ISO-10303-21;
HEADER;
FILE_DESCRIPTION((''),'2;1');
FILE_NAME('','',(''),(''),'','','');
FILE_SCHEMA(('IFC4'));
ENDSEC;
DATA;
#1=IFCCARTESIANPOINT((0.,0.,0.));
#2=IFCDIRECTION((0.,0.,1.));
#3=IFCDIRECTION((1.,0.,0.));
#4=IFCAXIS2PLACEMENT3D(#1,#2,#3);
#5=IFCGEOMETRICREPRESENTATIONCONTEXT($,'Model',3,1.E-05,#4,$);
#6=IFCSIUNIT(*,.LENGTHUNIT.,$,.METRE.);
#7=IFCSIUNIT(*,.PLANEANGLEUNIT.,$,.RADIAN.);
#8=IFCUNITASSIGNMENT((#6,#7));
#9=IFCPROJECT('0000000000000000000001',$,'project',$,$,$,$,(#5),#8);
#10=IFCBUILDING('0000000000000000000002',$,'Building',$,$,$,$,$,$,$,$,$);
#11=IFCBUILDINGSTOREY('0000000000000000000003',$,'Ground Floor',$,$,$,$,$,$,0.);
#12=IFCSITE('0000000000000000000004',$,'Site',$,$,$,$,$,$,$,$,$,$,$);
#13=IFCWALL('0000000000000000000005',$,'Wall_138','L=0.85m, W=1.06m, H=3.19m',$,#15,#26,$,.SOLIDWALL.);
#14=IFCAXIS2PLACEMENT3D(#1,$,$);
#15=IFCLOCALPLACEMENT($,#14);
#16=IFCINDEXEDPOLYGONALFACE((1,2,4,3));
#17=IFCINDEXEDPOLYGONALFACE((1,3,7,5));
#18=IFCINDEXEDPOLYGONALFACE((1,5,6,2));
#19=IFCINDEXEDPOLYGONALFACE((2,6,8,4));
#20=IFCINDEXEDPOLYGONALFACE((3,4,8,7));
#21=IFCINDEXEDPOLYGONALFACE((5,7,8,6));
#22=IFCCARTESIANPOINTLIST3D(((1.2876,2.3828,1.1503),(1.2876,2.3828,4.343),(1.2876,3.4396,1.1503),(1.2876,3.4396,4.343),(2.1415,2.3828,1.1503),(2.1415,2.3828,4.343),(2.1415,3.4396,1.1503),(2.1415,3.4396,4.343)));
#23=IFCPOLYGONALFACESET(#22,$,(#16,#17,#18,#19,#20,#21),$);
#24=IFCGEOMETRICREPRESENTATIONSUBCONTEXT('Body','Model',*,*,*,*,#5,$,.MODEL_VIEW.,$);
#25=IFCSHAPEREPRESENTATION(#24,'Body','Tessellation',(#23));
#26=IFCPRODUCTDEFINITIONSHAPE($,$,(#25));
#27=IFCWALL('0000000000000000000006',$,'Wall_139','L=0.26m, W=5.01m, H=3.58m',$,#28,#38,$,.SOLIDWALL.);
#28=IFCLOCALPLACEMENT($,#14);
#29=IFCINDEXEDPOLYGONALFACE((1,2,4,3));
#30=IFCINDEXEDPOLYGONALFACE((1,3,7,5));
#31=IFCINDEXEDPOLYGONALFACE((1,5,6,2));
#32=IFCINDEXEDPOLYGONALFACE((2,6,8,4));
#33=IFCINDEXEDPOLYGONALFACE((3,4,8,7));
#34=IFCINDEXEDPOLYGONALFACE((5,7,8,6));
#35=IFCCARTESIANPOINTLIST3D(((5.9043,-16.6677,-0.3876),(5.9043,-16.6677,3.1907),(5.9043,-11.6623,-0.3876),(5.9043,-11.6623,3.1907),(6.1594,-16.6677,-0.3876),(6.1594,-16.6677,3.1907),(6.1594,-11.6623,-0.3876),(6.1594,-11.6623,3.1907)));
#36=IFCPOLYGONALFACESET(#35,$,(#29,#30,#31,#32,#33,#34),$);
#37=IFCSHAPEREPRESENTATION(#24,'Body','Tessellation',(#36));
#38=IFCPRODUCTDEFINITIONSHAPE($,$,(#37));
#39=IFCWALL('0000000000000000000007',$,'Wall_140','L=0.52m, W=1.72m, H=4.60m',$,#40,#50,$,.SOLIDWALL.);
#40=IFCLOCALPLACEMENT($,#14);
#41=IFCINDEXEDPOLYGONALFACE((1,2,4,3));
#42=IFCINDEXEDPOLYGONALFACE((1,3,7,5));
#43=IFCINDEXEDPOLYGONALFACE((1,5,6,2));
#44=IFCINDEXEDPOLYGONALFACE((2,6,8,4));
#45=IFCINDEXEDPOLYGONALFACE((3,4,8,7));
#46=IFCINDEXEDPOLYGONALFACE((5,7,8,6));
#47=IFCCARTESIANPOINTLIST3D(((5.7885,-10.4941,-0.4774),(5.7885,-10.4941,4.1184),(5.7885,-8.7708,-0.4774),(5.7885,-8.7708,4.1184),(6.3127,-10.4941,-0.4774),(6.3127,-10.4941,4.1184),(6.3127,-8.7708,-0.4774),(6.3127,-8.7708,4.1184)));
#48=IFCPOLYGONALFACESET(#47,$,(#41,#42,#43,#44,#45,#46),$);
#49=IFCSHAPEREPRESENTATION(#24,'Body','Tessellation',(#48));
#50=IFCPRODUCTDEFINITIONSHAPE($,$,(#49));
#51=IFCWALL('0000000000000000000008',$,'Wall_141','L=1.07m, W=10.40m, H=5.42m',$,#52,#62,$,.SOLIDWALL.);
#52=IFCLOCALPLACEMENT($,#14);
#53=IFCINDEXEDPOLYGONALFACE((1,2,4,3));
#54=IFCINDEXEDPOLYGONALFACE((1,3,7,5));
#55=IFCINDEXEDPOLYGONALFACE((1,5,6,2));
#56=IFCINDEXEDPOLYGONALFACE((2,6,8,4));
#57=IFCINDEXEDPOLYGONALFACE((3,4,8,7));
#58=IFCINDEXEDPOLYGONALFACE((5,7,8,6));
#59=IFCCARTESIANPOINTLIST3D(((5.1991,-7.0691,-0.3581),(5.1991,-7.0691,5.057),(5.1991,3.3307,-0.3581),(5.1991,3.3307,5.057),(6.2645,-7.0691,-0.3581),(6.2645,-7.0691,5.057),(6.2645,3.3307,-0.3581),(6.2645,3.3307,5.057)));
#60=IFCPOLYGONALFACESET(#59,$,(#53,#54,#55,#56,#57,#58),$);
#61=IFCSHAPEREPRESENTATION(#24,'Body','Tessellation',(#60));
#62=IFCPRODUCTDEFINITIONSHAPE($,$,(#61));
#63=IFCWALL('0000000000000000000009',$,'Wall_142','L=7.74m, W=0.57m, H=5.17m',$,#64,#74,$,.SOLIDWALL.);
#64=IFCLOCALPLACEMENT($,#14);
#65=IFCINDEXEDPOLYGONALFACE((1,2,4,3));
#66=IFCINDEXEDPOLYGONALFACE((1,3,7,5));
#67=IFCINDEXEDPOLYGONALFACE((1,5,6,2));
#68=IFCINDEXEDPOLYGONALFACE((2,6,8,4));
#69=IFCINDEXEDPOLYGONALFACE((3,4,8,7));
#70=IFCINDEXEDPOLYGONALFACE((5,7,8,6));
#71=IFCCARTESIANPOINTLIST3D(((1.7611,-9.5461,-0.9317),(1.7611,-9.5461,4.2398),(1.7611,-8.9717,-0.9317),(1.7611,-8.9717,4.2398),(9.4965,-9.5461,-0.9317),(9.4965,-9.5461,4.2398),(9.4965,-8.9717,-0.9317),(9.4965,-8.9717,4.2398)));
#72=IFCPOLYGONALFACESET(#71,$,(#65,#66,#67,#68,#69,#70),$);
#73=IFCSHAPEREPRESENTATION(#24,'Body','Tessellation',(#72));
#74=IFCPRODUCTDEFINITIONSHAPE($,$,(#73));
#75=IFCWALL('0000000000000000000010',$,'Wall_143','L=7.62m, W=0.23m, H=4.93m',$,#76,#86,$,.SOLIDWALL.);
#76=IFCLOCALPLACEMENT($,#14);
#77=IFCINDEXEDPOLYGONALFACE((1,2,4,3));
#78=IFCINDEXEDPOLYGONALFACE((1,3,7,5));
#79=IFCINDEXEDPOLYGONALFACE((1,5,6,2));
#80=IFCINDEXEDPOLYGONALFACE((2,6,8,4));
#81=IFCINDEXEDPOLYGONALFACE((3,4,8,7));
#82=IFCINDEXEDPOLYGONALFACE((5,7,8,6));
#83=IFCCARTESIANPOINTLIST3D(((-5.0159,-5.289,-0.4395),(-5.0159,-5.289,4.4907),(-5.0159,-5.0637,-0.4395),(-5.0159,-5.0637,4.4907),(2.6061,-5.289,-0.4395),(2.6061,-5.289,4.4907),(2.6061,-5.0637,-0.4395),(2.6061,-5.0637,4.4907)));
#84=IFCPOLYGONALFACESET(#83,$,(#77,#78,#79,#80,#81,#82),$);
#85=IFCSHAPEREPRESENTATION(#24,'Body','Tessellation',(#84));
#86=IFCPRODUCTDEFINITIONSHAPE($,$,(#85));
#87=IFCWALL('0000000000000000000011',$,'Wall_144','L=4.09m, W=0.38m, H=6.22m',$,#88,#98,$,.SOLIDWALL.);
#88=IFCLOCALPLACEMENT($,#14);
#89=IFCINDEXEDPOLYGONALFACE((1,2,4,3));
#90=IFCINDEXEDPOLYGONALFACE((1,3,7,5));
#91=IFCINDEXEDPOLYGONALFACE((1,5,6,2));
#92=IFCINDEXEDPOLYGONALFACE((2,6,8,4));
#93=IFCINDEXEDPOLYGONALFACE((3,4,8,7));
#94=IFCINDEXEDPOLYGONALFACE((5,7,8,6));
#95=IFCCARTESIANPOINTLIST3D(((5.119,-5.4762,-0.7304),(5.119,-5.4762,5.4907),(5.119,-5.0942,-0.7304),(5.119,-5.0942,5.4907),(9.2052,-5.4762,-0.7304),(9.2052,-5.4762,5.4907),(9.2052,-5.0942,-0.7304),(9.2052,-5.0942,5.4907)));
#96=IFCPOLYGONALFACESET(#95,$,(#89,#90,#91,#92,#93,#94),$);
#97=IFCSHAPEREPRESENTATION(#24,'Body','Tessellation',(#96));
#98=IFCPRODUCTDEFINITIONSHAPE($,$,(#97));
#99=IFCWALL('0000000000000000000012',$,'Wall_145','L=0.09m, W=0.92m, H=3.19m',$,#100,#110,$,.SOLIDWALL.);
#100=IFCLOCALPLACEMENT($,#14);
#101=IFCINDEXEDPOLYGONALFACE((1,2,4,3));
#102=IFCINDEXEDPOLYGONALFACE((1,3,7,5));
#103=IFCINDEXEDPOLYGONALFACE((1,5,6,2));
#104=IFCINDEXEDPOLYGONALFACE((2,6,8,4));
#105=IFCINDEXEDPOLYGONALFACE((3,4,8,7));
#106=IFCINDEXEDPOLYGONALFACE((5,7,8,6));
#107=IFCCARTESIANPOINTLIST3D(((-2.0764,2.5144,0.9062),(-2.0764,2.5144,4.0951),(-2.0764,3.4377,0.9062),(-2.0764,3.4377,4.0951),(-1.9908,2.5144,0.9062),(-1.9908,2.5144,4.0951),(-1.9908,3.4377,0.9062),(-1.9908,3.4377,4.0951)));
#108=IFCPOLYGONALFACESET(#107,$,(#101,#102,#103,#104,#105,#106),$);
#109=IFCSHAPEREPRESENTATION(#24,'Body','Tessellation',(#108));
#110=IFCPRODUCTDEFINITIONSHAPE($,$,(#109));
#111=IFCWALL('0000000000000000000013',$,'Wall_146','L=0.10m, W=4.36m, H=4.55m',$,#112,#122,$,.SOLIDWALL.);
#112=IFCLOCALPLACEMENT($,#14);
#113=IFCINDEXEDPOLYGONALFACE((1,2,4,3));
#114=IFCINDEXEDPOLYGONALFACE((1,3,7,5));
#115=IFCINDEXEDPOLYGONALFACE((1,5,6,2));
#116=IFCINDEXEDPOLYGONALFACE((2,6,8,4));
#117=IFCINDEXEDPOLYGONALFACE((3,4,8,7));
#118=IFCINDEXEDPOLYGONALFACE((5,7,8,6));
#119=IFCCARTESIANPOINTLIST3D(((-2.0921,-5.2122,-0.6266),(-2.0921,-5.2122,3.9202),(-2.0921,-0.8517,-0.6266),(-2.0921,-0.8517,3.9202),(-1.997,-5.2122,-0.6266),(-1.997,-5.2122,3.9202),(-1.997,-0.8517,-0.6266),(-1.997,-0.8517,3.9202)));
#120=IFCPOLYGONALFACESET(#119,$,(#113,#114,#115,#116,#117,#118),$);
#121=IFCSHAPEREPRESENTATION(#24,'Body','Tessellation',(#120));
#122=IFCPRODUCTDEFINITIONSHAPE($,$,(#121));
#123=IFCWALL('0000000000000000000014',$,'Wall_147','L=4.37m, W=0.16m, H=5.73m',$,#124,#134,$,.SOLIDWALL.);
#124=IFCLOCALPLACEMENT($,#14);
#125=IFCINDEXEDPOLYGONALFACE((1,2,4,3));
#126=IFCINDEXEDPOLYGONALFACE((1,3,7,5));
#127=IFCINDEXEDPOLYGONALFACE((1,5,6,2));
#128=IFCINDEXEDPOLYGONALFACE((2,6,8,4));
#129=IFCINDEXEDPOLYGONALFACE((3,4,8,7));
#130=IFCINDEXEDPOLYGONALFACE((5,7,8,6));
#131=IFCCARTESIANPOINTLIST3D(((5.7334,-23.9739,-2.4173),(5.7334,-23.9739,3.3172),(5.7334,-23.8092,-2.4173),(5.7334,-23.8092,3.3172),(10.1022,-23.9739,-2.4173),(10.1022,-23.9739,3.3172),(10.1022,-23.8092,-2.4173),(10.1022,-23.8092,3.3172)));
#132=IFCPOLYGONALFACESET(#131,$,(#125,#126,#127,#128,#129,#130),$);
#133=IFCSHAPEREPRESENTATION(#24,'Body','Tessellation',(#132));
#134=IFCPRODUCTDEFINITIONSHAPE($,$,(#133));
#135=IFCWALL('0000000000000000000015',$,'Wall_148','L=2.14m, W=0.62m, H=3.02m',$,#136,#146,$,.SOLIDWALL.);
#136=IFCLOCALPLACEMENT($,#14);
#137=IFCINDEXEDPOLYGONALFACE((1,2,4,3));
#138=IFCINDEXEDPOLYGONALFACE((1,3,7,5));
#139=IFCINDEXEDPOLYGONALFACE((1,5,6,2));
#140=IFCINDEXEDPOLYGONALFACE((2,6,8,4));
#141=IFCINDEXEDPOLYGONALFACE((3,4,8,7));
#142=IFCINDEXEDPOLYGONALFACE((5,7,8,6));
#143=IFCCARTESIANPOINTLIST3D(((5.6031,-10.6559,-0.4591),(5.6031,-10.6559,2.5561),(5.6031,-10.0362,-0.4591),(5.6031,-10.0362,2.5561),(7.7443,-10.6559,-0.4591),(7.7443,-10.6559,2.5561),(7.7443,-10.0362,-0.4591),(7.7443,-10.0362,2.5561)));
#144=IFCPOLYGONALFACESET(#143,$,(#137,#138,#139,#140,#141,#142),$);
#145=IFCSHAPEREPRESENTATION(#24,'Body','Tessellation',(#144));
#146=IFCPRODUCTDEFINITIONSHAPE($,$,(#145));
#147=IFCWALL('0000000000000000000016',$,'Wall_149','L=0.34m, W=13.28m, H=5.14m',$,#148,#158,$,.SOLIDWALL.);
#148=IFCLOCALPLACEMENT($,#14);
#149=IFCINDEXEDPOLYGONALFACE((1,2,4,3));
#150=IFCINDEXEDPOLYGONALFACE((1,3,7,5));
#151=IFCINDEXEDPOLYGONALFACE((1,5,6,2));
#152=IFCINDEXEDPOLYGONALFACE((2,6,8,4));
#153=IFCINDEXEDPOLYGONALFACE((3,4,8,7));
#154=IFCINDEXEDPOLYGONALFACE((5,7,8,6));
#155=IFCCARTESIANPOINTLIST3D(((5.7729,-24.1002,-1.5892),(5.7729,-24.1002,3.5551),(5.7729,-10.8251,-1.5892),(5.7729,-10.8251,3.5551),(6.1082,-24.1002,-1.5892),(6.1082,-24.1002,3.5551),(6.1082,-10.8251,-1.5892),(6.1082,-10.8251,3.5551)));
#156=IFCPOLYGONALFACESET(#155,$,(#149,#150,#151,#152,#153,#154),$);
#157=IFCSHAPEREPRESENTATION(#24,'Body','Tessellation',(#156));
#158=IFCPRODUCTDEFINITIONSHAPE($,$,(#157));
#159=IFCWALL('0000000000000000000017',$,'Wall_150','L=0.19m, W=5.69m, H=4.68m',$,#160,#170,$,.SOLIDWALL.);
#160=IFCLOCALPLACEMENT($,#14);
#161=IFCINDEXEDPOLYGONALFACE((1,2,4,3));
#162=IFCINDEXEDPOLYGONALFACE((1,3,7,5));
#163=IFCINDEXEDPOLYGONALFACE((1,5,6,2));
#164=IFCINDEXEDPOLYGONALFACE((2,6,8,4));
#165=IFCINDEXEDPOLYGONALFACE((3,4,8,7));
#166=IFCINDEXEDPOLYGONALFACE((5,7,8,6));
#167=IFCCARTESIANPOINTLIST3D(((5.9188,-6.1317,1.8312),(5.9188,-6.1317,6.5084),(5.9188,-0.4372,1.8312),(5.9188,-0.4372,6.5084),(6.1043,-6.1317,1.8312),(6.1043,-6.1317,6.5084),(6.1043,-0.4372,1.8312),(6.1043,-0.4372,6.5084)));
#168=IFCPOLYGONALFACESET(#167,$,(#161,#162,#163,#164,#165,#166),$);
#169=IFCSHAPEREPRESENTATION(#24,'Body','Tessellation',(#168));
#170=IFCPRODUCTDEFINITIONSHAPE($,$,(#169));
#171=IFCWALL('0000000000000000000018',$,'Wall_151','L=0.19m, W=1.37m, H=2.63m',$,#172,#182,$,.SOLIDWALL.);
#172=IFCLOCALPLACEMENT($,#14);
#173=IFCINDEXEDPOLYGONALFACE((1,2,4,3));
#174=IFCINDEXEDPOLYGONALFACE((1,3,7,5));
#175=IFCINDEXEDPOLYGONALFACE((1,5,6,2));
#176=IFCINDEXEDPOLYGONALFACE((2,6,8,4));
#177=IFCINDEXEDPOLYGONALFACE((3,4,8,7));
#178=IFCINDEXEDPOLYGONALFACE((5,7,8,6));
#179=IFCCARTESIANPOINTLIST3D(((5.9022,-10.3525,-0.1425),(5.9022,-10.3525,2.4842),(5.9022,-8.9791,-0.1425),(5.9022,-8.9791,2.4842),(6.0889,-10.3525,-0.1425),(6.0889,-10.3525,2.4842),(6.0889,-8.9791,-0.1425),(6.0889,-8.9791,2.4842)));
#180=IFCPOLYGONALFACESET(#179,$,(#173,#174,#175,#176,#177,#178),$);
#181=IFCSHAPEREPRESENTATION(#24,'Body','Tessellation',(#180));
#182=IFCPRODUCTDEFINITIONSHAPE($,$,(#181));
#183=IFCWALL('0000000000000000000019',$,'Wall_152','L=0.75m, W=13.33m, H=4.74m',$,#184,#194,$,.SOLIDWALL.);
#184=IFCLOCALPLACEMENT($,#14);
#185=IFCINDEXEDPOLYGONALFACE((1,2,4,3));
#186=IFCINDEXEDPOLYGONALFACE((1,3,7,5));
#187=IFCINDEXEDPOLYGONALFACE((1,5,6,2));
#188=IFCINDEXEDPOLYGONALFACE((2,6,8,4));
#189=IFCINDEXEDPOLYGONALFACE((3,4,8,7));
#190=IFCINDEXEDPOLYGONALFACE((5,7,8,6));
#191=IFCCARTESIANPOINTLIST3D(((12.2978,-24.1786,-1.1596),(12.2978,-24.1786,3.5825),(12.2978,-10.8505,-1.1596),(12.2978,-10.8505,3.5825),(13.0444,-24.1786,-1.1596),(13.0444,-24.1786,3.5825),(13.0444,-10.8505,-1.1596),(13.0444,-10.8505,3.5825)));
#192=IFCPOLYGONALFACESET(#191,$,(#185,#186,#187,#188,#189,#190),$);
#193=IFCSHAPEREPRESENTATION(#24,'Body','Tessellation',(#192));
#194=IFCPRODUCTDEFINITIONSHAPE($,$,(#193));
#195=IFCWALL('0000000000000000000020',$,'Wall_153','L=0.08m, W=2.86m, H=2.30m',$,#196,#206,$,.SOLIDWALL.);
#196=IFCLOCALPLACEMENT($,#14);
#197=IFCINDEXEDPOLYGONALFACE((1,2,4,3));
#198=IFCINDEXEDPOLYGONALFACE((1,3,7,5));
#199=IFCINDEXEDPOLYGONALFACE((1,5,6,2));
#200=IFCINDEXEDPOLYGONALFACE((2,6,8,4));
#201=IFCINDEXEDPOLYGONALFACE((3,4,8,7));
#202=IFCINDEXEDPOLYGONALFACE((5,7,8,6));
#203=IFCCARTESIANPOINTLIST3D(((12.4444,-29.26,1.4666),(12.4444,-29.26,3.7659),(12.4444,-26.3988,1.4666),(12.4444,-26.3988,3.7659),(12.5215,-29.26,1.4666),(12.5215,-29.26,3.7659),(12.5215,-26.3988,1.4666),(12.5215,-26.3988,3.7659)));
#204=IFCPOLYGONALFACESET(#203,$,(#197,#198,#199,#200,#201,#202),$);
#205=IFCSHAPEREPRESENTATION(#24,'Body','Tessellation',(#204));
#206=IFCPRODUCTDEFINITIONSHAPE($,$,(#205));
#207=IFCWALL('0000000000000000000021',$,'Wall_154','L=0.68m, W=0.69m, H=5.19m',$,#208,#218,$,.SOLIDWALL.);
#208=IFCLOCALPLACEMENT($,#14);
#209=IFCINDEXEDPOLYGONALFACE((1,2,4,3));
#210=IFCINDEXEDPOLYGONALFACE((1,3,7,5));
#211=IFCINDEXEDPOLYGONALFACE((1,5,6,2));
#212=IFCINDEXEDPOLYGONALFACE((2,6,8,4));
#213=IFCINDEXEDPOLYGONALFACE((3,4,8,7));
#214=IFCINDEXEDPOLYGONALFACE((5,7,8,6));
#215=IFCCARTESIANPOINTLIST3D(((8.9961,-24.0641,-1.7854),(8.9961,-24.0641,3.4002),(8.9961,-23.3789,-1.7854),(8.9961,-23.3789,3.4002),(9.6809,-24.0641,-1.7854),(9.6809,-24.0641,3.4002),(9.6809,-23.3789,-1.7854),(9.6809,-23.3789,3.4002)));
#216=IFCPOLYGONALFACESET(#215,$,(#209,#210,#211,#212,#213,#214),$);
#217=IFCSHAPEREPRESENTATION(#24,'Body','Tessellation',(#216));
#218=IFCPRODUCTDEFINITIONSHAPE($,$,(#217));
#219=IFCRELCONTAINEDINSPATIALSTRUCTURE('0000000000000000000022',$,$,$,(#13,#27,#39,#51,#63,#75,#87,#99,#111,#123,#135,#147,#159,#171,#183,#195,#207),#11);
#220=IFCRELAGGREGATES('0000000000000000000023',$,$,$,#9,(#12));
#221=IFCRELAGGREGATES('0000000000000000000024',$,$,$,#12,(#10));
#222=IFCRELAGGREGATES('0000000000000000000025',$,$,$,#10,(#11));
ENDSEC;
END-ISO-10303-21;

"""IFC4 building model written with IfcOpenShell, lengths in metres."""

from ifc_helpers import new_model, si_unit, frame, origin_with_axes, origin_2d, context, subcontext, project, spatial, rectangle, extrude, element, save


model = new_model("IFC4")

# Units and contexts
model_context = context("Model", 3, precision=1e-05, world=origin_with_axes())
body_context = subcontext(model_context, "Body", "Model", "MODEL_VIEW")
ifc_project = project(units=[si_unit("LENGTHUNIT", "METRE"), si_unit("PLANEANGLEUNIT", "RADIAN")], contexts=[model_context])

# Site, building, storey
site = spatial("IfcSite", under=ifc_project, Name="Site")
building = spatial("IfcBuilding", under=site, Name="Building")
storey = spatial("IfcBuildingStorey", under=building, Name="Ground Floor", Elevation=0.0)

# Walls
element("IfcWall", 1, inside=storey, Name="Wall_138", Description="L=0.85m, W=1.06m, H=3.19m", PredefinedType="SOLIDWALL", context=body_context, shape_type="SweptSolid", body=[
    extrude(rectangle(XDim=0.8539, YDim=1.0568, at=origin_2d()), frame((1.7145, 2.9112, 1.1503), z_axis=(0.0, 0.0, 1.0), x_axis=(1.0, 0.0, 0.0)), (0.0, 0.0, 1.0), 3.1927),
])
element("IfcWall", 2, inside=storey, Name="Wall_139", Description="L=0.26m, W=5.01m, H=3.58m", PredefinedType="SOLIDWALL", context=body_context, shape_type="SweptSolid", body=[
    extrude(rectangle(XDim=0.255, YDim=5.0054, at=origin_2d()), frame((6.0319, -14.165, -0.3876), z_axis=(0.0, 0.0, 1.0), x_axis=(1.0, 0.0, 0.0)), (0.0, 0.0, 1.0), 3.5783),
])
element("IfcWall", 3, inside=storey, Name="Wall_140", Description="L=0.52m, W=1.72m, H=4.60m", PredefinedType="SOLIDWALL", context=body_context, shape_type="SweptSolid", body=[
    extrude(rectangle(XDim=0.5242, YDim=1.7233, at=origin_2d()), frame((6.0506, -9.6325, -0.4774), z_axis=(0.0, 0.0, 1.0), x_axis=(1.0, 0.0, 0.0)), (0.0, 0.0, 1.0), 4.5957),
])
element("IfcWall", 4, inside=storey, Name="Wall_141", Description="L=1.07m, W=10.40m, H=5.42m", PredefinedType="SOLIDWALL", context=body_context, shape_type="SweptSolid", body=[
    extrude(rectangle(XDim=1.0655, YDim=10.3998, at=origin_2d()), frame((5.7318, -1.8692, -0.3581), z_axis=(0.0, 0.0, 1.0), x_axis=(1.0, 0.0, 0.0)), (0.0, 0.0, 1.0), 5.415),
])
element("IfcWall", 5, inside=storey, Name="Wall_142", Description="L=7.74m, W=0.57m, H=5.17m", PredefinedType="SOLIDWALL", context=body_context, shape_type="SweptSolid", body=[
    extrude(rectangle(XDim=7.7353, YDim=0.5744, at=origin_2d()), frame((5.6288, -9.2589, -0.9317), z_axis=(0.0, 0.0, 1.0), x_axis=(1.0, 0.0, 0.0)), (0.0, 0.0, 1.0), 5.1715),
])
element("IfcWall", 6, inside=storey, Name="Wall_143", Description="L=7.62m, W=0.23m, H=4.93m", PredefinedType="SOLIDWALL", context=body_context, shape_type="SweptSolid", body=[
    extrude(rectangle(XDim=7.622, YDim=0.2253, at=origin_2d()), frame((-1.2049, -5.1763, -0.4395), z_axis=(0.0, 0.0, 1.0), x_axis=(1.0, 0.0, 0.0)), (0.0, 0.0, 1.0), 4.9302),
])
element("IfcWall", 7, inside=storey, Name="Wall_144", Description="L=4.09m, W=0.38m, H=6.22m", PredefinedType="SOLIDWALL", context=body_context, shape_type="SweptSolid", body=[
    extrude(rectangle(XDim=4.0862, YDim=0.382, at=origin_2d()), frame((7.1621, -5.2852, -0.7304), z_axis=(0.0, 0.0, 1.0), x_axis=(1.0, 0.0, 0.0)), (0.0, 0.0, 1.0), 6.221),
])
element("IfcWall", 8, inside=storey, Name="Wall_145", Description="L=0.09m, W=0.92m, H=3.19m", PredefinedType="SOLIDWALL", context=body_context, shape_type="SweptSolid", body=[
    extrude(rectangle(XDim=0.0856, YDim=0.9233, at=origin_2d()), frame((-2.0336, 2.9761, 0.9062), z_axis=(0.0, 0.0, 1.0), x_axis=(1.0, 0.0, 0.0)), (0.0, 0.0, 1.0), 3.1889),
])
element("IfcWall", 9, inside=storey, Name="Wall_146", Description="L=0.10m, W=4.36m, H=4.55m", PredefinedType="SOLIDWALL", context=body_context, shape_type="SweptSolid", body=[
    extrude(rectangle(XDim=0.0952, YDim=4.3605, at=origin_2d()), frame((-2.0445, -3.0319, -0.6266), z_axis=(0.0, 0.0, 1.0), x_axis=(1.0, 0.0, 0.0)), (0.0, 0.0, 1.0), 4.5468),
])
element("IfcWall", 10, inside=storey, Name="Wall_147", Description="L=4.37m, W=0.16m, H=5.73m", PredefinedType="SOLIDWALL", context=body_context, shape_type="SweptSolid", body=[
    extrude(rectangle(XDim=4.3689, YDim=0.1647, at=origin_2d()), frame((7.9178, -23.8915, -2.4173), z_axis=(0.0, 0.0, 1.0), x_axis=(1.0, 0.0, 0.0)), (0.0, 0.0, 1.0), 5.7345),
])
element("IfcWall", 11, inside=storey, Name="Wall_148", Description="L=2.14m, W=0.62m, H=3.02m", PredefinedType="SOLIDWALL", context=body_context, shape_type="SweptSolid", body=[
    extrude(rectangle(XDim=2.1412, YDim=0.6196, at=origin_2d()), frame((6.6737, -10.3461, -0.4591), z_axis=(0.0, 0.0, 1.0), x_axis=(1.0, 0.0, 0.0)), (0.0, 0.0, 1.0), 3.0152),
])
element("IfcWall", 12, inside=storey, Name="Wall_149", Description="L=0.34m, W=13.28m, H=5.14m", PredefinedType="SOLIDWALL", context=body_context, shape_type="SweptSolid", body=[
    extrude(rectangle(XDim=0.3353, YDim=13.2751, at=origin_2d()), frame((5.9405, -17.4627, -1.5892), z_axis=(0.0, 0.0, 1.0), x_axis=(1.0, 0.0, 0.0)), (0.0, 0.0, 1.0), 5.1443),
])
element("IfcWall", 13, inside=storey, Name="Wall_150", Description="L=0.19m, W=5.69m, H=4.68m", PredefinedType="SOLIDWALL", context=body_context, shape_type="SweptSolid", body=[
    extrude(rectangle(XDim=0.1855, YDim=5.6945, at=origin_2d()), frame((6.0116, -3.2845, 1.8312), z_axis=(0.0, 0.0, 1.0), x_axis=(1.0, 0.0, 0.0)), (0.0, 0.0, 1.0), 4.6772),
])
element("IfcWall", 14, inside=storey, Name="Wall_151", Description="L=0.19m, W=1.37m, H=2.63m", PredefinedType="SOLIDWALL", context=body_context, shape_type="SweptSolid", body=[
    extrude(rectangle(XDim=0.1867, YDim=1.3734, at=origin_2d()), frame((5.9956, -9.6658, -0.1425), z_axis=(0.0, 0.0, 1.0), x_axis=(1.0, 0.0, 0.0)), (0.0, 0.0, 1.0), 2.6267),
])
element("IfcWall", 15, inside=storey, Name="Wall_152", Description="L=0.75m, W=13.33m, H=4.74m", PredefinedType="SOLIDWALL", context=body_context, shape_type="SweptSolid", body=[
    extrude(rectangle(XDim=0.7465, YDim=13.3281, at=origin_2d()), frame((12.6711, -17.5145, -1.1596), z_axis=(0.0, 0.0, 1.0), x_axis=(1.0, 0.0, 0.0)), (0.0, 0.0, 1.0), 4.7421),
])
element("IfcWall", 16, inside=storey, Name="Wall_153", Description="L=0.08m, W=2.86m, H=2.30m", PredefinedType="SOLIDWALL", context=body_context, shape_type="SweptSolid", body=[
    extrude(rectangle(XDim=0.0771, YDim=2.8612, at=origin_2d()), frame((12.4829, -27.8294, 1.4666), z_axis=(0.0, 0.0, 1.0), x_axis=(1.0, 0.0, 0.0)), (0.0, 0.0, 1.0), 2.2993),
])
element("IfcWall", 17, inside=storey, Name="Wall_154", Description="L=0.68m, W=0.69m, H=5.19m", PredefinedType="SOLIDWALL", context=body_context, shape_type="SweptSolid", body=[
    extrude(rectangle(XDim=0.6848, YDim=0.6852, at=origin_2d()), frame((9.3385, -23.7215, -1.7854), z_axis=(0.0, 0.0, 1.0), x_axis=(1.0, 0.0, 0.0)), (0.0, 0.0, 1.0), 5.1856),
])

save(model, "model.ifc")
